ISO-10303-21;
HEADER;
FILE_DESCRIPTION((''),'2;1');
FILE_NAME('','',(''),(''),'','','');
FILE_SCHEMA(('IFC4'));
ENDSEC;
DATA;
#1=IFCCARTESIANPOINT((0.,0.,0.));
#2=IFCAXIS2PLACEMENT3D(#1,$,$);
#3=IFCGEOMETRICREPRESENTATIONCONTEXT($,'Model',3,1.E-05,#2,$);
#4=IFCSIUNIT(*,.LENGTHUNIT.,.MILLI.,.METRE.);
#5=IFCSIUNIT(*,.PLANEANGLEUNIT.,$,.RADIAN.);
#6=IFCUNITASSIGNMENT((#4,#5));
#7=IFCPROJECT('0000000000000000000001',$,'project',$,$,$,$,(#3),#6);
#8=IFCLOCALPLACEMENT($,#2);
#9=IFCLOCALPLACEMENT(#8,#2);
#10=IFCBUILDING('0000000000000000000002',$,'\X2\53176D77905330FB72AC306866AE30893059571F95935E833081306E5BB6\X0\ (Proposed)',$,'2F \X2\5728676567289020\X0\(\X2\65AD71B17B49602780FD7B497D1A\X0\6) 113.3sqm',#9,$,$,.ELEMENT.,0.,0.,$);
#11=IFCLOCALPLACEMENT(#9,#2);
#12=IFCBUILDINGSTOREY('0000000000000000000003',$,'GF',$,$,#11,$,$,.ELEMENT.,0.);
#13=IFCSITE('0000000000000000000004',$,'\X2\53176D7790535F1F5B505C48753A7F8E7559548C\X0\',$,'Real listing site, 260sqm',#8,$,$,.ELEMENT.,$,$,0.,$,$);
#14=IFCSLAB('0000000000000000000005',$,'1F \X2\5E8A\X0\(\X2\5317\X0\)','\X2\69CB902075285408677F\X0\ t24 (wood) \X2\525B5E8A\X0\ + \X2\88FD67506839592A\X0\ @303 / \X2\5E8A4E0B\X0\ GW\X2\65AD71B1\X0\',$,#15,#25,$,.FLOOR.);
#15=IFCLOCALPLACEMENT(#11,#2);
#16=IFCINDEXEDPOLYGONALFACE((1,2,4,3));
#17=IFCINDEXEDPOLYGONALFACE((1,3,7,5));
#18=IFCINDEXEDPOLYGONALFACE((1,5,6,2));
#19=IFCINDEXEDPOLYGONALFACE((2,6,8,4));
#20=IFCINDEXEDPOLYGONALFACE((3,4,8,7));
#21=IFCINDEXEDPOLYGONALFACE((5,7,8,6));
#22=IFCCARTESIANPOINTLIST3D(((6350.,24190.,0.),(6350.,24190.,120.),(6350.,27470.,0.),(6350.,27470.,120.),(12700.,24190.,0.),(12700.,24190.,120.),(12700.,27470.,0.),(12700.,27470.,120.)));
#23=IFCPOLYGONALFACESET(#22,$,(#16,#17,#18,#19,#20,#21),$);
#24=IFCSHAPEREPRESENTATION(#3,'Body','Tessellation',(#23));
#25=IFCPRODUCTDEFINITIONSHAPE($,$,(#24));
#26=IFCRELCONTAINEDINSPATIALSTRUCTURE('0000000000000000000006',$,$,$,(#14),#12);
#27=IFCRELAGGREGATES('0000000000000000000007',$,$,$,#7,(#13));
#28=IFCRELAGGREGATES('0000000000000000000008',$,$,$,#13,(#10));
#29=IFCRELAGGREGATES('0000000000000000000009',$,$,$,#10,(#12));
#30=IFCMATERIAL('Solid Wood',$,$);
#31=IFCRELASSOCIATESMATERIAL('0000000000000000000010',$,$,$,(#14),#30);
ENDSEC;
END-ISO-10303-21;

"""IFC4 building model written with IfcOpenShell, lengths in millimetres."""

from ifc_helpers import new_model, si_unit, frame, frame_2d, origin, place, context, project, spatial, rectangle, extrude, material, element, save


model = new_model("IFC4")

# Units and contexts
model_context = context("Model", 3, precision=1e-05, world=origin())
ifc_project = project(units=[si_unit("LENGTHUNIT", "METRE", prefix="MILLI"), si_unit("PLANEANGLEUNIT", "RADIAN")], contexts=[model_context])

# Site, building, storey
site_placement = place(None, origin())
site = spatial("IfcSite", under=ifc_project, at=site_placement, Name="北海道弟子屈町美留和", ObjectType="Real listing site, 260sqm", CompositionType="ELEMENT", RefElevation=0.0)
building_placement = place(site_placement, origin())
building = spatial("IfcBuilding", under=site, at=building_placement, Name="北海道・犬と暮らす土間広めの家 (Proposed)", ObjectType="2F 在来木造(断熱等性能等級6) 113.3sqm", CompositionType="ELEMENT", ElevationOfRefHeight=0.0, ElevationOfTerrain=0.0)
storey_placement = place(building_placement, origin())
storey = spatial("IfcBuildingStorey", under=building, at=storey_placement, Name="GF", CompositionType="ELEMENT", Elevation=0.0)

# Shared definitions
ifc_material_1 = material(Name="Solid Wood")

# Slab
slab_1_placement = place(storey_placement, frame((3175.0, 12095.0, 0.0)))
element("IfcSlab", 1, at=slab_1_placement, inside=storey, material=ifc_material_1, Name="1F 床(北)", Description="構造用合板 t24 (wood) 剛床 + 製材根太 @303 / 床下 GW断熱", PredefinedType="FLOOR", context=model_context, shape_type="SweptSolid", body=[
    extrude(rectangle(XDim=6350.0, YDim=3280.0, at=frame_2d((3175.0, 1640.0))), frame((3175.0, 12095.0, 0.0)), (0.0, 0.0, 1.0), 120.0),
])

save(model, "model.ifc")
